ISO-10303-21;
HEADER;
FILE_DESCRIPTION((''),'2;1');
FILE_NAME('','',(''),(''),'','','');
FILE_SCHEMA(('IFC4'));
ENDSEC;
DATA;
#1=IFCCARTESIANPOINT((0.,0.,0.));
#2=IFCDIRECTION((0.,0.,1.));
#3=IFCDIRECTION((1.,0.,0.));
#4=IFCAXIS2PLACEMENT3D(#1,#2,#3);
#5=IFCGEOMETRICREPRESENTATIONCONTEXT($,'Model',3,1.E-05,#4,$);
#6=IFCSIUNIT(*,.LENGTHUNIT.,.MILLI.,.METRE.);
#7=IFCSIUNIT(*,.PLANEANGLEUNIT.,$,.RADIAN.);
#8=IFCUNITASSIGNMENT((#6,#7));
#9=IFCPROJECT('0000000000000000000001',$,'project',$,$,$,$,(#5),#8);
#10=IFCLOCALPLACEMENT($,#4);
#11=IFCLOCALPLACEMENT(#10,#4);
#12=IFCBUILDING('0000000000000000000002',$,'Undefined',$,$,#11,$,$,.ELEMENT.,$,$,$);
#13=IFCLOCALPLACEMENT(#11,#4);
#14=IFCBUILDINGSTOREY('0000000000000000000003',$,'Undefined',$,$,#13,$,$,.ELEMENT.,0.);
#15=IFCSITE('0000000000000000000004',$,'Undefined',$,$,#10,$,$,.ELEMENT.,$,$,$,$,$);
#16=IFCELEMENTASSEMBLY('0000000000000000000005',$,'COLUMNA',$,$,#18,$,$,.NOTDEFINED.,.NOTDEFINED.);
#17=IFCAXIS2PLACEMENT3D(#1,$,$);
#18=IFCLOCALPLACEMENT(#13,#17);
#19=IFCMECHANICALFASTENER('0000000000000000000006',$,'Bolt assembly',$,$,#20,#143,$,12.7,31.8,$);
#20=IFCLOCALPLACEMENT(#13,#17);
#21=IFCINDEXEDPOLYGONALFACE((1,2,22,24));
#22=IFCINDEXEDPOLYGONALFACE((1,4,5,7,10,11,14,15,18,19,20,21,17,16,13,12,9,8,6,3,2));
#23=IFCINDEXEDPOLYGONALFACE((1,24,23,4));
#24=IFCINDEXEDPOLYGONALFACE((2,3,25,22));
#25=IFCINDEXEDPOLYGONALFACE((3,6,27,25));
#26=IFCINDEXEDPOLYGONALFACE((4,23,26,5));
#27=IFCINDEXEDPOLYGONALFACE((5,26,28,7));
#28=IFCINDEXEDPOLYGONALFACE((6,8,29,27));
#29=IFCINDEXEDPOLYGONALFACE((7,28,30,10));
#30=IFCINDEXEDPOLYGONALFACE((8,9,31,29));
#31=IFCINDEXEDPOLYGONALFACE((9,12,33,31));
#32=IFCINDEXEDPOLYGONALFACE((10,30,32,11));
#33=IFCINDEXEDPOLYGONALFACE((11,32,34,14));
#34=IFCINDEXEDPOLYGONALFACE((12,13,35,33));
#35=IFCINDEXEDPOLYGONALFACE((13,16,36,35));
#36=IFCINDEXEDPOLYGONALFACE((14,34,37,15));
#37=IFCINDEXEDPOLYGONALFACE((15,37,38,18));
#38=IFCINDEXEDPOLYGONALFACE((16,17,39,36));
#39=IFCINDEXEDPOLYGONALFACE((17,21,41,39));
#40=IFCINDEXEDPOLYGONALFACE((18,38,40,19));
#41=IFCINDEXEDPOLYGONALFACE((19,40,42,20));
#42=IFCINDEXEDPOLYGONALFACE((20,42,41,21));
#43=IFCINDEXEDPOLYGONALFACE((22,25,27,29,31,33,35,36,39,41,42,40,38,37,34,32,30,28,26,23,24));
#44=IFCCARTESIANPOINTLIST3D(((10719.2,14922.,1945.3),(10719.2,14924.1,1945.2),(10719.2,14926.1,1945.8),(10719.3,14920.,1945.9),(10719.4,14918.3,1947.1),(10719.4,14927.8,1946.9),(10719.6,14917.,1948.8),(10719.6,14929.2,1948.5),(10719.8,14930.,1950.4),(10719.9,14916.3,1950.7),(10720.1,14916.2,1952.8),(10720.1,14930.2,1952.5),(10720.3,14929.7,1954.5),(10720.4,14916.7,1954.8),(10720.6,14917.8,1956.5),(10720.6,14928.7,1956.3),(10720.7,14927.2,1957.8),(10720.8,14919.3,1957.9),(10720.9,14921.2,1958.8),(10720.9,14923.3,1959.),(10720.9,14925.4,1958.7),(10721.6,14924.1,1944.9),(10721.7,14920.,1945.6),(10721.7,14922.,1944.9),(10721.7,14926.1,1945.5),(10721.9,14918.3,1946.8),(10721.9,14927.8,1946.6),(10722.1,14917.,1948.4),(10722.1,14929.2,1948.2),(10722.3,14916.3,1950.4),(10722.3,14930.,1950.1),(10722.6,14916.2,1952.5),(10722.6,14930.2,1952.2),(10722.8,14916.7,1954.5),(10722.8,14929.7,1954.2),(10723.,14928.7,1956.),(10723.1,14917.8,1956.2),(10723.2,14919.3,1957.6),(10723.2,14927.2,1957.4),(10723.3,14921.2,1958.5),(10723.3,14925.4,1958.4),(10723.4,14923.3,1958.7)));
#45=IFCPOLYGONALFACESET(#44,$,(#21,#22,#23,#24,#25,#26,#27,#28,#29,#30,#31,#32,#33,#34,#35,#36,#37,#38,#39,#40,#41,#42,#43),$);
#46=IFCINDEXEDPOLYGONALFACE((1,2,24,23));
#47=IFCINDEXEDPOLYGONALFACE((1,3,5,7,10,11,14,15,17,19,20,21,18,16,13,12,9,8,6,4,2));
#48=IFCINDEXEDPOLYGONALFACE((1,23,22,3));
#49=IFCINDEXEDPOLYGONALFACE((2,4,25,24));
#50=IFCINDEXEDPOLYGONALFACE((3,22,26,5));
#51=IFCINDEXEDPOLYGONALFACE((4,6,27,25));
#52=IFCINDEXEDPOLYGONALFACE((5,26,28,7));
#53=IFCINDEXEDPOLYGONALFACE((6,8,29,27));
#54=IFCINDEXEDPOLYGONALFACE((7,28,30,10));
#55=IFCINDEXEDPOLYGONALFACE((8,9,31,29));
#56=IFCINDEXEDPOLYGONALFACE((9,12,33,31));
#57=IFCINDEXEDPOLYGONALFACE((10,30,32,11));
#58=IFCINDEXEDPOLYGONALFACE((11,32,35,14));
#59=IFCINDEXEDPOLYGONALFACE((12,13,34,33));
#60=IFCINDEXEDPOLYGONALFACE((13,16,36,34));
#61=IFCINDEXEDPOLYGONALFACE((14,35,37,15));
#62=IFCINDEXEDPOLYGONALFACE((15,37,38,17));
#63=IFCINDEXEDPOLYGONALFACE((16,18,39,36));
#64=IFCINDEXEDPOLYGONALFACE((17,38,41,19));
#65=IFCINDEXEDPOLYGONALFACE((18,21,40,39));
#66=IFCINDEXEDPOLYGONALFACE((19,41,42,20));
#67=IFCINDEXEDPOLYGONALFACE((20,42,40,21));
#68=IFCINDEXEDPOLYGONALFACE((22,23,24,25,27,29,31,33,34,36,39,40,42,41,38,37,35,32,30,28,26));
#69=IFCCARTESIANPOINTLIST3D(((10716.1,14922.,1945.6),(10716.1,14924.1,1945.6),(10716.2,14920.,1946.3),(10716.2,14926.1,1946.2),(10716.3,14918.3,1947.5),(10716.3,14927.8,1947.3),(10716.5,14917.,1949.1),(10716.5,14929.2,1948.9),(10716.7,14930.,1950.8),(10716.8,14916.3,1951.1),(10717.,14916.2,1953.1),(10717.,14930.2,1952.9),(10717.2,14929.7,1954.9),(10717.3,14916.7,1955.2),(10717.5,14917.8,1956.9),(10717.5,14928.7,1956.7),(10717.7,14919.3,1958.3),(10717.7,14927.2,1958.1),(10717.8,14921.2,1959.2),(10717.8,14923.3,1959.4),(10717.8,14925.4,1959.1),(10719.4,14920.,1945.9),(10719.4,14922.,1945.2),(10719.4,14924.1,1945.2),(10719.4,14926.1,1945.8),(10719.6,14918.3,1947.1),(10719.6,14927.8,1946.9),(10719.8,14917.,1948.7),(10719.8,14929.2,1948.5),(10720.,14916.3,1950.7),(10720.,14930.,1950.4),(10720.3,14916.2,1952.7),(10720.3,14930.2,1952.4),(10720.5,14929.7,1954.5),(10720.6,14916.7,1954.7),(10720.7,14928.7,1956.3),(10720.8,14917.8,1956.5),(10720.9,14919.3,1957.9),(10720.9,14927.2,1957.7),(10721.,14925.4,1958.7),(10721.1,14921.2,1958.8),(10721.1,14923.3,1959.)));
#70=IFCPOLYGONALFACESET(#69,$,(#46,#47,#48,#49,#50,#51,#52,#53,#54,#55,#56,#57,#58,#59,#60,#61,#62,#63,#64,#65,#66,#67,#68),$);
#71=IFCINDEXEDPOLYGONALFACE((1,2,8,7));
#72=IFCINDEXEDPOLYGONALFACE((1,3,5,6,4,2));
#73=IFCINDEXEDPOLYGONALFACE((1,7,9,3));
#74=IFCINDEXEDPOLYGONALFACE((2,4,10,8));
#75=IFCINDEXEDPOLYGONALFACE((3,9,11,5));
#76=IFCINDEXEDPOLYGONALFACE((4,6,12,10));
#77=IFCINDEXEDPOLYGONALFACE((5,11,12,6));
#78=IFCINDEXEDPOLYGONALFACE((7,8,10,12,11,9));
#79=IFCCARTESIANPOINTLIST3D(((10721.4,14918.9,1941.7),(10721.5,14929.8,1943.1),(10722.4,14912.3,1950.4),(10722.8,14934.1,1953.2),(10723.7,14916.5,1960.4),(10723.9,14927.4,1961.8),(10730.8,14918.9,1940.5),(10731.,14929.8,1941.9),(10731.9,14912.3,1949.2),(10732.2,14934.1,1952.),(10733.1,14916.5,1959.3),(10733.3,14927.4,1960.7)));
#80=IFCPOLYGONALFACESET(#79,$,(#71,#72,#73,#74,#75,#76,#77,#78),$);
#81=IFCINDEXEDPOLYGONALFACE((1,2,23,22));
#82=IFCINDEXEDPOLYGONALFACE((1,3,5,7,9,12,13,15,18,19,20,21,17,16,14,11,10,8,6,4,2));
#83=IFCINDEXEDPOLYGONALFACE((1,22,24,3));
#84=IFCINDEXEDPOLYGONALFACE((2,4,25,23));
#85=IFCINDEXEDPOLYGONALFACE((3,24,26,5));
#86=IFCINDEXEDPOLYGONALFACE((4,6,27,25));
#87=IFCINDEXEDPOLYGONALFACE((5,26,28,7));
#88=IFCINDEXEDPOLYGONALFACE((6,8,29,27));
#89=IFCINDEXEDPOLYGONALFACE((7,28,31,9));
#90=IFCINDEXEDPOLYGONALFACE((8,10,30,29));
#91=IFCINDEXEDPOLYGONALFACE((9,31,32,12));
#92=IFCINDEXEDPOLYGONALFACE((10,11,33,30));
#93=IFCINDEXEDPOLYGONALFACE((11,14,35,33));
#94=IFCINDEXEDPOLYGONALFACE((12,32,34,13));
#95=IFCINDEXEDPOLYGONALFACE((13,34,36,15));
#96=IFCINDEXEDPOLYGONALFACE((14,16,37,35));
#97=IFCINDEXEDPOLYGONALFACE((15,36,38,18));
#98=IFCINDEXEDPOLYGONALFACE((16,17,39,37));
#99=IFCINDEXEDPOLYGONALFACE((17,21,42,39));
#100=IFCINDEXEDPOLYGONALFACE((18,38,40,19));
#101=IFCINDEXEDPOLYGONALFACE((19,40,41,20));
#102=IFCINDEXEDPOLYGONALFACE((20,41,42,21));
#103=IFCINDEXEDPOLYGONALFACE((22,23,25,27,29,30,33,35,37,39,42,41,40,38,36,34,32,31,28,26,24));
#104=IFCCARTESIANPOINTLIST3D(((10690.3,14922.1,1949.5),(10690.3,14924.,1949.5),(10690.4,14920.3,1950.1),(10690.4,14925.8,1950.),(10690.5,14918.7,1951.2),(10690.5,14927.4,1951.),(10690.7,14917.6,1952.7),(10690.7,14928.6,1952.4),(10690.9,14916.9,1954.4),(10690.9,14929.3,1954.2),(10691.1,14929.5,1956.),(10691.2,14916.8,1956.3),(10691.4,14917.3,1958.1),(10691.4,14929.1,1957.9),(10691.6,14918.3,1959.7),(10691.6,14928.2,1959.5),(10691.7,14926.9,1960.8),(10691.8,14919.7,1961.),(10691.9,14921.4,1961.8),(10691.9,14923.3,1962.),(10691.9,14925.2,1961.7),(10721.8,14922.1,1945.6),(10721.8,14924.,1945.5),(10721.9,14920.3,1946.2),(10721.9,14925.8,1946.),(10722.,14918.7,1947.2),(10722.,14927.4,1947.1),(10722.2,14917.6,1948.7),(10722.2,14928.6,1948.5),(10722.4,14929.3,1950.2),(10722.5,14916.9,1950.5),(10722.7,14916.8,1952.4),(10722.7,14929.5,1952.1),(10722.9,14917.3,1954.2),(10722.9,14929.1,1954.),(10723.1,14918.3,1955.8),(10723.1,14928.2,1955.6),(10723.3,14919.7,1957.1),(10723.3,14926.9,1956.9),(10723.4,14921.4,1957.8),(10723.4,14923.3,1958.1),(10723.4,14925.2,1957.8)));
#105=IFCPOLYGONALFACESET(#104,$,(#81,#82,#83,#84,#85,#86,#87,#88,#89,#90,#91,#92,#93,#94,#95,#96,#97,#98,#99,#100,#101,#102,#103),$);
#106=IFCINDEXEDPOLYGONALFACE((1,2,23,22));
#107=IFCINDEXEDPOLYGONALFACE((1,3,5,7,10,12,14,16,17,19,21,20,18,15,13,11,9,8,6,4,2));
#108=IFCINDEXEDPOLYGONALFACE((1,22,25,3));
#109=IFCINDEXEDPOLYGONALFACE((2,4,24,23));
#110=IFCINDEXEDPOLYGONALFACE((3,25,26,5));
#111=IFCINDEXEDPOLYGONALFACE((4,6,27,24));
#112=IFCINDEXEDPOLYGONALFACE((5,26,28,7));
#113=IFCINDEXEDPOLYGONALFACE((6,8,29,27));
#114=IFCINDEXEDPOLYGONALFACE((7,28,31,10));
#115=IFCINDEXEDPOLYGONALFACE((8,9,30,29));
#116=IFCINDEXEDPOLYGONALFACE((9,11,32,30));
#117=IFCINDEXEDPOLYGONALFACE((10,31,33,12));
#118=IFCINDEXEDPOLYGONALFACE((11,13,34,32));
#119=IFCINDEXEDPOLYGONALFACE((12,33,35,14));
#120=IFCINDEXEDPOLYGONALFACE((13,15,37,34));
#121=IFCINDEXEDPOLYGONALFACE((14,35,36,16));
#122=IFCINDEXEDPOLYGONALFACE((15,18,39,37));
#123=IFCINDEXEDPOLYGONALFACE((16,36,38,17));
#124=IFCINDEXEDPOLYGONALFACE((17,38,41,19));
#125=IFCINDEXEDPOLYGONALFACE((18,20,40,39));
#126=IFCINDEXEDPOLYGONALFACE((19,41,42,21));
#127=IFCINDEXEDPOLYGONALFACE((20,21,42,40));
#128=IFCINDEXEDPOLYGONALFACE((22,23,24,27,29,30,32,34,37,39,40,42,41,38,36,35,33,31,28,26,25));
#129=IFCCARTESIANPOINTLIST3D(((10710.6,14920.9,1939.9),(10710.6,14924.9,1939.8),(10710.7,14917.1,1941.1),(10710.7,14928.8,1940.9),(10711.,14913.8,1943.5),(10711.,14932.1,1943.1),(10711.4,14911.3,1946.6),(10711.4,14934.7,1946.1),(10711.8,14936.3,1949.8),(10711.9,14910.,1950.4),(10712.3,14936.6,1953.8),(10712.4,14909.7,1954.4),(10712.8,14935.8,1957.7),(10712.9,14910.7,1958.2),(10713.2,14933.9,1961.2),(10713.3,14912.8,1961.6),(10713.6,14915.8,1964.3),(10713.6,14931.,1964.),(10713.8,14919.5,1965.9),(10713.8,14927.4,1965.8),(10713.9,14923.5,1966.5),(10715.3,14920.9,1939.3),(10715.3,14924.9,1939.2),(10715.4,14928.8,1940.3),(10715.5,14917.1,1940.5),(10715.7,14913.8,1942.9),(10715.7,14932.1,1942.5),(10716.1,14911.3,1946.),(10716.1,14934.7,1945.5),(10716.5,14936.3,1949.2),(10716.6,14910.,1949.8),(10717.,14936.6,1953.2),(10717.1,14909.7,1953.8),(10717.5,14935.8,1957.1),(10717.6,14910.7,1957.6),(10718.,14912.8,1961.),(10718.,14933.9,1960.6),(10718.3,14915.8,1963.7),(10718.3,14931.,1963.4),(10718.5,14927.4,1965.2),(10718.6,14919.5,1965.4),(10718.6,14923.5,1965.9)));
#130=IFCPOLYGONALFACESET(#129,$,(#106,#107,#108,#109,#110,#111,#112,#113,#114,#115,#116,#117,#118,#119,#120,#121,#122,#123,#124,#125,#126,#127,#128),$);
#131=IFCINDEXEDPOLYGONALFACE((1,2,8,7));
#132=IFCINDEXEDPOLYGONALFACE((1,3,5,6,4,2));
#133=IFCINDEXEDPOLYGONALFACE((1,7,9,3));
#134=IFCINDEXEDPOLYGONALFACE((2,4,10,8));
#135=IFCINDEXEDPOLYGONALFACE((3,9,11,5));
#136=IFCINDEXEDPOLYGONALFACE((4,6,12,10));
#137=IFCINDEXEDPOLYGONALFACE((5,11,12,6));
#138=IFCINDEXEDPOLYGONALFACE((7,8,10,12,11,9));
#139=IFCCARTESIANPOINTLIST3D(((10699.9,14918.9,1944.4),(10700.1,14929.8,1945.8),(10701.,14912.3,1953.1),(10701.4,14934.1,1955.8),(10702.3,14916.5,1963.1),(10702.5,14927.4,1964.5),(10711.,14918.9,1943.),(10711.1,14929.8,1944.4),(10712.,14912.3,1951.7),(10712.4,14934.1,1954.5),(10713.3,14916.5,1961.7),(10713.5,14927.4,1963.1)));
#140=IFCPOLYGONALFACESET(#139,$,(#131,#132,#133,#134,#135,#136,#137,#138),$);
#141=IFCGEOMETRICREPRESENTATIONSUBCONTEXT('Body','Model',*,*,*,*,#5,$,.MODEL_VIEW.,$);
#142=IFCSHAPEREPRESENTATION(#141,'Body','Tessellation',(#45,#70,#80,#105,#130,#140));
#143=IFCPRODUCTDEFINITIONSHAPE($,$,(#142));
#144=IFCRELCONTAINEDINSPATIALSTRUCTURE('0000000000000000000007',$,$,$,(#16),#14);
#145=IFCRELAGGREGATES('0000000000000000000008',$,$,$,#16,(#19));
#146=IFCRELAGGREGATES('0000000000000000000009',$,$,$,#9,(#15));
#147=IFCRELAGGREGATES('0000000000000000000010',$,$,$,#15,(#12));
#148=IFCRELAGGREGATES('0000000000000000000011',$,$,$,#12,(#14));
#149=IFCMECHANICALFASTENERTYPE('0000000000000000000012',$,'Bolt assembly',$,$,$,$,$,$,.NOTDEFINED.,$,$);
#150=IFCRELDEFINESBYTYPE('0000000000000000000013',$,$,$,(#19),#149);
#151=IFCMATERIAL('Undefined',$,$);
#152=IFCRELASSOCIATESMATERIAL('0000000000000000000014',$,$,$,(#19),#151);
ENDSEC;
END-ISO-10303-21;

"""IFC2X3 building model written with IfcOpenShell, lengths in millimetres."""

from ifc_helpers import new_model, si_unit, frame, origin_with_axes, origin_2d_with_axis, place, context, subcontext, project, spatial, polyline, circle, outline, extrude, source, transform, mapped, material, type_object, element, aggregate, save


model = new_model("IFC2X3")

# Units and contexts
model_context = context("Model", 3, precision=1e-05, world=origin_with_axes())
body_context = subcontext(model_context, "Body", "Model", "MODEL_VIEW")
ifc_project = project(units=[si_unit("LENGTHUNIT", "METRE", prefix="MILLI"), si_unit("PLANEANGLEUNIT", "RADIAN")], contexts=[model_context])

# Site, building, storey
site_placement = place(None, origin_with_axes())
site = spatial("IfcSite", under=ifc_project, at=site_placement, Name="Undefined", CompositionType="ELEMENT")
building_placement = place(site_placement, origin_with_axes())
building = spatial("IfcBuilding", under=site, at=building_placement, Name="Undefined", CompositionType="ELEMENT")
storey_placement = place(building_placement, origin_with_axes())
storey = spatial("IfcBuildingStorey", under=building, at=storey_placement, Name="Undefined", CompositionType="ELEMENT", Elevation=0.0)

# Element assembly
assembly_1_placement = place(storey_placement, origin_with_axes())
assembly_1 = element("IfcElementAssembly", 1, at=assembly_1_placement, inside=storey, Name="COLUMNA", AssemblyPlace="NOTDEFINED", PredefinedType="NOTDEFINED")

# Shared definitions
ifc_material_1 = material(Name="Undefined")
mechanical_fastener_type = type_object("IfcMechanicalFastenerType", Name="Bolt assembly")

# Mechanical fastener
shared_shape_1 = source(origin_with_axes(), body_context, "Body", "SweptSolid", [
    extrude(circle(Radius=7.0, at=origin_2d_with_axis()), frame((0.0, -2.4, 0.0), z_axis=(0.0, 1.0, 0.0), x_axis=(1.0, 0.0, 0.0)), (0.0, 0.0, 1.0), 2.5),
    extrude(circle(Radius=7.0, at=origin_2d_with_axis()), frame((0.0, -0.1, 0.0), z_axis=(0.0, 1.0, 0.0), x_axis=(1.0, 0.0, 0.0)), (0.0, 0.0, 1.0), 3.3),
    extrude(outline(polyline([(9.5, -5.5), (9.5, 5.5), (0.0, 11.0), (-9.5, 5.5), (-9.5, -5.5), (0.0, -11.0), (9.5, -5.5)])), frame((0.0, -12.0, 0.0), z_axis=(0.0, 1.0, 0.0), x_axis=(1.0, 0.0, 0.0)), (0.0, 0.0, 1.0), 9.5),
    extrude(circle(Radius=6.3, at=origin_2d_with_axis()), frame((0.0, -2.5, 0.0), z_axis=(0.0, 1.0, 0.0), x_axis=(1.0, 0.0, 0.0)), (0.0, 0.0, 1.0), 31.8),
    extrude(circle(Radius=13.5, at=origin_2d_with_axis()), frame((0.0, 3.2, 0.0), z_axis=(0.0, 1.0, 0.0), x_axis=(1.0, 0.0, 0.0)), (0.0, 0.0, 1.0), 4.8),
    extrude(outline(polyline([(9.5, -5.5), (9.5, 5.5), (0.0, 11.0), (-9.5, 5.5), (-9.5, -5.5), (0.0, -11.0), (9.5, -5.5)])), frame((0.0, 8.0, 0.0), z_axis=(0.0, 1.0, 0.0), x_axis=(1.0, 0.0, 0.0)), (0.0, 0.0, 1.0), 11.1),
])
mechanical_fastener_1_placement = place(assembly_1_placement, frame((10720.1, 14923.2, 1952.1), z_axis=(0.098611, -0.606774, 0.788734), x_axis=(0.075276, 0.794875, 0.602086)))
mechanical_fastener_1 = element("IfcMechanicalFastener", 2, at=mechanical_fastener_1_placement, type_object=mechanical_fastener_type, material=ifc_material_1, Name="Bolt assembly", NominalDiameter=12.7, NominalLength=31.8, context=body_context, shape_type="MappedRepresentation", body=[
    mapped(shared_shape_1, transform((0.0, 0.0, 0.0))),
])
aggregate(assembly_1, [mechanical_fastener_1])

save(model, "model.ifc")
